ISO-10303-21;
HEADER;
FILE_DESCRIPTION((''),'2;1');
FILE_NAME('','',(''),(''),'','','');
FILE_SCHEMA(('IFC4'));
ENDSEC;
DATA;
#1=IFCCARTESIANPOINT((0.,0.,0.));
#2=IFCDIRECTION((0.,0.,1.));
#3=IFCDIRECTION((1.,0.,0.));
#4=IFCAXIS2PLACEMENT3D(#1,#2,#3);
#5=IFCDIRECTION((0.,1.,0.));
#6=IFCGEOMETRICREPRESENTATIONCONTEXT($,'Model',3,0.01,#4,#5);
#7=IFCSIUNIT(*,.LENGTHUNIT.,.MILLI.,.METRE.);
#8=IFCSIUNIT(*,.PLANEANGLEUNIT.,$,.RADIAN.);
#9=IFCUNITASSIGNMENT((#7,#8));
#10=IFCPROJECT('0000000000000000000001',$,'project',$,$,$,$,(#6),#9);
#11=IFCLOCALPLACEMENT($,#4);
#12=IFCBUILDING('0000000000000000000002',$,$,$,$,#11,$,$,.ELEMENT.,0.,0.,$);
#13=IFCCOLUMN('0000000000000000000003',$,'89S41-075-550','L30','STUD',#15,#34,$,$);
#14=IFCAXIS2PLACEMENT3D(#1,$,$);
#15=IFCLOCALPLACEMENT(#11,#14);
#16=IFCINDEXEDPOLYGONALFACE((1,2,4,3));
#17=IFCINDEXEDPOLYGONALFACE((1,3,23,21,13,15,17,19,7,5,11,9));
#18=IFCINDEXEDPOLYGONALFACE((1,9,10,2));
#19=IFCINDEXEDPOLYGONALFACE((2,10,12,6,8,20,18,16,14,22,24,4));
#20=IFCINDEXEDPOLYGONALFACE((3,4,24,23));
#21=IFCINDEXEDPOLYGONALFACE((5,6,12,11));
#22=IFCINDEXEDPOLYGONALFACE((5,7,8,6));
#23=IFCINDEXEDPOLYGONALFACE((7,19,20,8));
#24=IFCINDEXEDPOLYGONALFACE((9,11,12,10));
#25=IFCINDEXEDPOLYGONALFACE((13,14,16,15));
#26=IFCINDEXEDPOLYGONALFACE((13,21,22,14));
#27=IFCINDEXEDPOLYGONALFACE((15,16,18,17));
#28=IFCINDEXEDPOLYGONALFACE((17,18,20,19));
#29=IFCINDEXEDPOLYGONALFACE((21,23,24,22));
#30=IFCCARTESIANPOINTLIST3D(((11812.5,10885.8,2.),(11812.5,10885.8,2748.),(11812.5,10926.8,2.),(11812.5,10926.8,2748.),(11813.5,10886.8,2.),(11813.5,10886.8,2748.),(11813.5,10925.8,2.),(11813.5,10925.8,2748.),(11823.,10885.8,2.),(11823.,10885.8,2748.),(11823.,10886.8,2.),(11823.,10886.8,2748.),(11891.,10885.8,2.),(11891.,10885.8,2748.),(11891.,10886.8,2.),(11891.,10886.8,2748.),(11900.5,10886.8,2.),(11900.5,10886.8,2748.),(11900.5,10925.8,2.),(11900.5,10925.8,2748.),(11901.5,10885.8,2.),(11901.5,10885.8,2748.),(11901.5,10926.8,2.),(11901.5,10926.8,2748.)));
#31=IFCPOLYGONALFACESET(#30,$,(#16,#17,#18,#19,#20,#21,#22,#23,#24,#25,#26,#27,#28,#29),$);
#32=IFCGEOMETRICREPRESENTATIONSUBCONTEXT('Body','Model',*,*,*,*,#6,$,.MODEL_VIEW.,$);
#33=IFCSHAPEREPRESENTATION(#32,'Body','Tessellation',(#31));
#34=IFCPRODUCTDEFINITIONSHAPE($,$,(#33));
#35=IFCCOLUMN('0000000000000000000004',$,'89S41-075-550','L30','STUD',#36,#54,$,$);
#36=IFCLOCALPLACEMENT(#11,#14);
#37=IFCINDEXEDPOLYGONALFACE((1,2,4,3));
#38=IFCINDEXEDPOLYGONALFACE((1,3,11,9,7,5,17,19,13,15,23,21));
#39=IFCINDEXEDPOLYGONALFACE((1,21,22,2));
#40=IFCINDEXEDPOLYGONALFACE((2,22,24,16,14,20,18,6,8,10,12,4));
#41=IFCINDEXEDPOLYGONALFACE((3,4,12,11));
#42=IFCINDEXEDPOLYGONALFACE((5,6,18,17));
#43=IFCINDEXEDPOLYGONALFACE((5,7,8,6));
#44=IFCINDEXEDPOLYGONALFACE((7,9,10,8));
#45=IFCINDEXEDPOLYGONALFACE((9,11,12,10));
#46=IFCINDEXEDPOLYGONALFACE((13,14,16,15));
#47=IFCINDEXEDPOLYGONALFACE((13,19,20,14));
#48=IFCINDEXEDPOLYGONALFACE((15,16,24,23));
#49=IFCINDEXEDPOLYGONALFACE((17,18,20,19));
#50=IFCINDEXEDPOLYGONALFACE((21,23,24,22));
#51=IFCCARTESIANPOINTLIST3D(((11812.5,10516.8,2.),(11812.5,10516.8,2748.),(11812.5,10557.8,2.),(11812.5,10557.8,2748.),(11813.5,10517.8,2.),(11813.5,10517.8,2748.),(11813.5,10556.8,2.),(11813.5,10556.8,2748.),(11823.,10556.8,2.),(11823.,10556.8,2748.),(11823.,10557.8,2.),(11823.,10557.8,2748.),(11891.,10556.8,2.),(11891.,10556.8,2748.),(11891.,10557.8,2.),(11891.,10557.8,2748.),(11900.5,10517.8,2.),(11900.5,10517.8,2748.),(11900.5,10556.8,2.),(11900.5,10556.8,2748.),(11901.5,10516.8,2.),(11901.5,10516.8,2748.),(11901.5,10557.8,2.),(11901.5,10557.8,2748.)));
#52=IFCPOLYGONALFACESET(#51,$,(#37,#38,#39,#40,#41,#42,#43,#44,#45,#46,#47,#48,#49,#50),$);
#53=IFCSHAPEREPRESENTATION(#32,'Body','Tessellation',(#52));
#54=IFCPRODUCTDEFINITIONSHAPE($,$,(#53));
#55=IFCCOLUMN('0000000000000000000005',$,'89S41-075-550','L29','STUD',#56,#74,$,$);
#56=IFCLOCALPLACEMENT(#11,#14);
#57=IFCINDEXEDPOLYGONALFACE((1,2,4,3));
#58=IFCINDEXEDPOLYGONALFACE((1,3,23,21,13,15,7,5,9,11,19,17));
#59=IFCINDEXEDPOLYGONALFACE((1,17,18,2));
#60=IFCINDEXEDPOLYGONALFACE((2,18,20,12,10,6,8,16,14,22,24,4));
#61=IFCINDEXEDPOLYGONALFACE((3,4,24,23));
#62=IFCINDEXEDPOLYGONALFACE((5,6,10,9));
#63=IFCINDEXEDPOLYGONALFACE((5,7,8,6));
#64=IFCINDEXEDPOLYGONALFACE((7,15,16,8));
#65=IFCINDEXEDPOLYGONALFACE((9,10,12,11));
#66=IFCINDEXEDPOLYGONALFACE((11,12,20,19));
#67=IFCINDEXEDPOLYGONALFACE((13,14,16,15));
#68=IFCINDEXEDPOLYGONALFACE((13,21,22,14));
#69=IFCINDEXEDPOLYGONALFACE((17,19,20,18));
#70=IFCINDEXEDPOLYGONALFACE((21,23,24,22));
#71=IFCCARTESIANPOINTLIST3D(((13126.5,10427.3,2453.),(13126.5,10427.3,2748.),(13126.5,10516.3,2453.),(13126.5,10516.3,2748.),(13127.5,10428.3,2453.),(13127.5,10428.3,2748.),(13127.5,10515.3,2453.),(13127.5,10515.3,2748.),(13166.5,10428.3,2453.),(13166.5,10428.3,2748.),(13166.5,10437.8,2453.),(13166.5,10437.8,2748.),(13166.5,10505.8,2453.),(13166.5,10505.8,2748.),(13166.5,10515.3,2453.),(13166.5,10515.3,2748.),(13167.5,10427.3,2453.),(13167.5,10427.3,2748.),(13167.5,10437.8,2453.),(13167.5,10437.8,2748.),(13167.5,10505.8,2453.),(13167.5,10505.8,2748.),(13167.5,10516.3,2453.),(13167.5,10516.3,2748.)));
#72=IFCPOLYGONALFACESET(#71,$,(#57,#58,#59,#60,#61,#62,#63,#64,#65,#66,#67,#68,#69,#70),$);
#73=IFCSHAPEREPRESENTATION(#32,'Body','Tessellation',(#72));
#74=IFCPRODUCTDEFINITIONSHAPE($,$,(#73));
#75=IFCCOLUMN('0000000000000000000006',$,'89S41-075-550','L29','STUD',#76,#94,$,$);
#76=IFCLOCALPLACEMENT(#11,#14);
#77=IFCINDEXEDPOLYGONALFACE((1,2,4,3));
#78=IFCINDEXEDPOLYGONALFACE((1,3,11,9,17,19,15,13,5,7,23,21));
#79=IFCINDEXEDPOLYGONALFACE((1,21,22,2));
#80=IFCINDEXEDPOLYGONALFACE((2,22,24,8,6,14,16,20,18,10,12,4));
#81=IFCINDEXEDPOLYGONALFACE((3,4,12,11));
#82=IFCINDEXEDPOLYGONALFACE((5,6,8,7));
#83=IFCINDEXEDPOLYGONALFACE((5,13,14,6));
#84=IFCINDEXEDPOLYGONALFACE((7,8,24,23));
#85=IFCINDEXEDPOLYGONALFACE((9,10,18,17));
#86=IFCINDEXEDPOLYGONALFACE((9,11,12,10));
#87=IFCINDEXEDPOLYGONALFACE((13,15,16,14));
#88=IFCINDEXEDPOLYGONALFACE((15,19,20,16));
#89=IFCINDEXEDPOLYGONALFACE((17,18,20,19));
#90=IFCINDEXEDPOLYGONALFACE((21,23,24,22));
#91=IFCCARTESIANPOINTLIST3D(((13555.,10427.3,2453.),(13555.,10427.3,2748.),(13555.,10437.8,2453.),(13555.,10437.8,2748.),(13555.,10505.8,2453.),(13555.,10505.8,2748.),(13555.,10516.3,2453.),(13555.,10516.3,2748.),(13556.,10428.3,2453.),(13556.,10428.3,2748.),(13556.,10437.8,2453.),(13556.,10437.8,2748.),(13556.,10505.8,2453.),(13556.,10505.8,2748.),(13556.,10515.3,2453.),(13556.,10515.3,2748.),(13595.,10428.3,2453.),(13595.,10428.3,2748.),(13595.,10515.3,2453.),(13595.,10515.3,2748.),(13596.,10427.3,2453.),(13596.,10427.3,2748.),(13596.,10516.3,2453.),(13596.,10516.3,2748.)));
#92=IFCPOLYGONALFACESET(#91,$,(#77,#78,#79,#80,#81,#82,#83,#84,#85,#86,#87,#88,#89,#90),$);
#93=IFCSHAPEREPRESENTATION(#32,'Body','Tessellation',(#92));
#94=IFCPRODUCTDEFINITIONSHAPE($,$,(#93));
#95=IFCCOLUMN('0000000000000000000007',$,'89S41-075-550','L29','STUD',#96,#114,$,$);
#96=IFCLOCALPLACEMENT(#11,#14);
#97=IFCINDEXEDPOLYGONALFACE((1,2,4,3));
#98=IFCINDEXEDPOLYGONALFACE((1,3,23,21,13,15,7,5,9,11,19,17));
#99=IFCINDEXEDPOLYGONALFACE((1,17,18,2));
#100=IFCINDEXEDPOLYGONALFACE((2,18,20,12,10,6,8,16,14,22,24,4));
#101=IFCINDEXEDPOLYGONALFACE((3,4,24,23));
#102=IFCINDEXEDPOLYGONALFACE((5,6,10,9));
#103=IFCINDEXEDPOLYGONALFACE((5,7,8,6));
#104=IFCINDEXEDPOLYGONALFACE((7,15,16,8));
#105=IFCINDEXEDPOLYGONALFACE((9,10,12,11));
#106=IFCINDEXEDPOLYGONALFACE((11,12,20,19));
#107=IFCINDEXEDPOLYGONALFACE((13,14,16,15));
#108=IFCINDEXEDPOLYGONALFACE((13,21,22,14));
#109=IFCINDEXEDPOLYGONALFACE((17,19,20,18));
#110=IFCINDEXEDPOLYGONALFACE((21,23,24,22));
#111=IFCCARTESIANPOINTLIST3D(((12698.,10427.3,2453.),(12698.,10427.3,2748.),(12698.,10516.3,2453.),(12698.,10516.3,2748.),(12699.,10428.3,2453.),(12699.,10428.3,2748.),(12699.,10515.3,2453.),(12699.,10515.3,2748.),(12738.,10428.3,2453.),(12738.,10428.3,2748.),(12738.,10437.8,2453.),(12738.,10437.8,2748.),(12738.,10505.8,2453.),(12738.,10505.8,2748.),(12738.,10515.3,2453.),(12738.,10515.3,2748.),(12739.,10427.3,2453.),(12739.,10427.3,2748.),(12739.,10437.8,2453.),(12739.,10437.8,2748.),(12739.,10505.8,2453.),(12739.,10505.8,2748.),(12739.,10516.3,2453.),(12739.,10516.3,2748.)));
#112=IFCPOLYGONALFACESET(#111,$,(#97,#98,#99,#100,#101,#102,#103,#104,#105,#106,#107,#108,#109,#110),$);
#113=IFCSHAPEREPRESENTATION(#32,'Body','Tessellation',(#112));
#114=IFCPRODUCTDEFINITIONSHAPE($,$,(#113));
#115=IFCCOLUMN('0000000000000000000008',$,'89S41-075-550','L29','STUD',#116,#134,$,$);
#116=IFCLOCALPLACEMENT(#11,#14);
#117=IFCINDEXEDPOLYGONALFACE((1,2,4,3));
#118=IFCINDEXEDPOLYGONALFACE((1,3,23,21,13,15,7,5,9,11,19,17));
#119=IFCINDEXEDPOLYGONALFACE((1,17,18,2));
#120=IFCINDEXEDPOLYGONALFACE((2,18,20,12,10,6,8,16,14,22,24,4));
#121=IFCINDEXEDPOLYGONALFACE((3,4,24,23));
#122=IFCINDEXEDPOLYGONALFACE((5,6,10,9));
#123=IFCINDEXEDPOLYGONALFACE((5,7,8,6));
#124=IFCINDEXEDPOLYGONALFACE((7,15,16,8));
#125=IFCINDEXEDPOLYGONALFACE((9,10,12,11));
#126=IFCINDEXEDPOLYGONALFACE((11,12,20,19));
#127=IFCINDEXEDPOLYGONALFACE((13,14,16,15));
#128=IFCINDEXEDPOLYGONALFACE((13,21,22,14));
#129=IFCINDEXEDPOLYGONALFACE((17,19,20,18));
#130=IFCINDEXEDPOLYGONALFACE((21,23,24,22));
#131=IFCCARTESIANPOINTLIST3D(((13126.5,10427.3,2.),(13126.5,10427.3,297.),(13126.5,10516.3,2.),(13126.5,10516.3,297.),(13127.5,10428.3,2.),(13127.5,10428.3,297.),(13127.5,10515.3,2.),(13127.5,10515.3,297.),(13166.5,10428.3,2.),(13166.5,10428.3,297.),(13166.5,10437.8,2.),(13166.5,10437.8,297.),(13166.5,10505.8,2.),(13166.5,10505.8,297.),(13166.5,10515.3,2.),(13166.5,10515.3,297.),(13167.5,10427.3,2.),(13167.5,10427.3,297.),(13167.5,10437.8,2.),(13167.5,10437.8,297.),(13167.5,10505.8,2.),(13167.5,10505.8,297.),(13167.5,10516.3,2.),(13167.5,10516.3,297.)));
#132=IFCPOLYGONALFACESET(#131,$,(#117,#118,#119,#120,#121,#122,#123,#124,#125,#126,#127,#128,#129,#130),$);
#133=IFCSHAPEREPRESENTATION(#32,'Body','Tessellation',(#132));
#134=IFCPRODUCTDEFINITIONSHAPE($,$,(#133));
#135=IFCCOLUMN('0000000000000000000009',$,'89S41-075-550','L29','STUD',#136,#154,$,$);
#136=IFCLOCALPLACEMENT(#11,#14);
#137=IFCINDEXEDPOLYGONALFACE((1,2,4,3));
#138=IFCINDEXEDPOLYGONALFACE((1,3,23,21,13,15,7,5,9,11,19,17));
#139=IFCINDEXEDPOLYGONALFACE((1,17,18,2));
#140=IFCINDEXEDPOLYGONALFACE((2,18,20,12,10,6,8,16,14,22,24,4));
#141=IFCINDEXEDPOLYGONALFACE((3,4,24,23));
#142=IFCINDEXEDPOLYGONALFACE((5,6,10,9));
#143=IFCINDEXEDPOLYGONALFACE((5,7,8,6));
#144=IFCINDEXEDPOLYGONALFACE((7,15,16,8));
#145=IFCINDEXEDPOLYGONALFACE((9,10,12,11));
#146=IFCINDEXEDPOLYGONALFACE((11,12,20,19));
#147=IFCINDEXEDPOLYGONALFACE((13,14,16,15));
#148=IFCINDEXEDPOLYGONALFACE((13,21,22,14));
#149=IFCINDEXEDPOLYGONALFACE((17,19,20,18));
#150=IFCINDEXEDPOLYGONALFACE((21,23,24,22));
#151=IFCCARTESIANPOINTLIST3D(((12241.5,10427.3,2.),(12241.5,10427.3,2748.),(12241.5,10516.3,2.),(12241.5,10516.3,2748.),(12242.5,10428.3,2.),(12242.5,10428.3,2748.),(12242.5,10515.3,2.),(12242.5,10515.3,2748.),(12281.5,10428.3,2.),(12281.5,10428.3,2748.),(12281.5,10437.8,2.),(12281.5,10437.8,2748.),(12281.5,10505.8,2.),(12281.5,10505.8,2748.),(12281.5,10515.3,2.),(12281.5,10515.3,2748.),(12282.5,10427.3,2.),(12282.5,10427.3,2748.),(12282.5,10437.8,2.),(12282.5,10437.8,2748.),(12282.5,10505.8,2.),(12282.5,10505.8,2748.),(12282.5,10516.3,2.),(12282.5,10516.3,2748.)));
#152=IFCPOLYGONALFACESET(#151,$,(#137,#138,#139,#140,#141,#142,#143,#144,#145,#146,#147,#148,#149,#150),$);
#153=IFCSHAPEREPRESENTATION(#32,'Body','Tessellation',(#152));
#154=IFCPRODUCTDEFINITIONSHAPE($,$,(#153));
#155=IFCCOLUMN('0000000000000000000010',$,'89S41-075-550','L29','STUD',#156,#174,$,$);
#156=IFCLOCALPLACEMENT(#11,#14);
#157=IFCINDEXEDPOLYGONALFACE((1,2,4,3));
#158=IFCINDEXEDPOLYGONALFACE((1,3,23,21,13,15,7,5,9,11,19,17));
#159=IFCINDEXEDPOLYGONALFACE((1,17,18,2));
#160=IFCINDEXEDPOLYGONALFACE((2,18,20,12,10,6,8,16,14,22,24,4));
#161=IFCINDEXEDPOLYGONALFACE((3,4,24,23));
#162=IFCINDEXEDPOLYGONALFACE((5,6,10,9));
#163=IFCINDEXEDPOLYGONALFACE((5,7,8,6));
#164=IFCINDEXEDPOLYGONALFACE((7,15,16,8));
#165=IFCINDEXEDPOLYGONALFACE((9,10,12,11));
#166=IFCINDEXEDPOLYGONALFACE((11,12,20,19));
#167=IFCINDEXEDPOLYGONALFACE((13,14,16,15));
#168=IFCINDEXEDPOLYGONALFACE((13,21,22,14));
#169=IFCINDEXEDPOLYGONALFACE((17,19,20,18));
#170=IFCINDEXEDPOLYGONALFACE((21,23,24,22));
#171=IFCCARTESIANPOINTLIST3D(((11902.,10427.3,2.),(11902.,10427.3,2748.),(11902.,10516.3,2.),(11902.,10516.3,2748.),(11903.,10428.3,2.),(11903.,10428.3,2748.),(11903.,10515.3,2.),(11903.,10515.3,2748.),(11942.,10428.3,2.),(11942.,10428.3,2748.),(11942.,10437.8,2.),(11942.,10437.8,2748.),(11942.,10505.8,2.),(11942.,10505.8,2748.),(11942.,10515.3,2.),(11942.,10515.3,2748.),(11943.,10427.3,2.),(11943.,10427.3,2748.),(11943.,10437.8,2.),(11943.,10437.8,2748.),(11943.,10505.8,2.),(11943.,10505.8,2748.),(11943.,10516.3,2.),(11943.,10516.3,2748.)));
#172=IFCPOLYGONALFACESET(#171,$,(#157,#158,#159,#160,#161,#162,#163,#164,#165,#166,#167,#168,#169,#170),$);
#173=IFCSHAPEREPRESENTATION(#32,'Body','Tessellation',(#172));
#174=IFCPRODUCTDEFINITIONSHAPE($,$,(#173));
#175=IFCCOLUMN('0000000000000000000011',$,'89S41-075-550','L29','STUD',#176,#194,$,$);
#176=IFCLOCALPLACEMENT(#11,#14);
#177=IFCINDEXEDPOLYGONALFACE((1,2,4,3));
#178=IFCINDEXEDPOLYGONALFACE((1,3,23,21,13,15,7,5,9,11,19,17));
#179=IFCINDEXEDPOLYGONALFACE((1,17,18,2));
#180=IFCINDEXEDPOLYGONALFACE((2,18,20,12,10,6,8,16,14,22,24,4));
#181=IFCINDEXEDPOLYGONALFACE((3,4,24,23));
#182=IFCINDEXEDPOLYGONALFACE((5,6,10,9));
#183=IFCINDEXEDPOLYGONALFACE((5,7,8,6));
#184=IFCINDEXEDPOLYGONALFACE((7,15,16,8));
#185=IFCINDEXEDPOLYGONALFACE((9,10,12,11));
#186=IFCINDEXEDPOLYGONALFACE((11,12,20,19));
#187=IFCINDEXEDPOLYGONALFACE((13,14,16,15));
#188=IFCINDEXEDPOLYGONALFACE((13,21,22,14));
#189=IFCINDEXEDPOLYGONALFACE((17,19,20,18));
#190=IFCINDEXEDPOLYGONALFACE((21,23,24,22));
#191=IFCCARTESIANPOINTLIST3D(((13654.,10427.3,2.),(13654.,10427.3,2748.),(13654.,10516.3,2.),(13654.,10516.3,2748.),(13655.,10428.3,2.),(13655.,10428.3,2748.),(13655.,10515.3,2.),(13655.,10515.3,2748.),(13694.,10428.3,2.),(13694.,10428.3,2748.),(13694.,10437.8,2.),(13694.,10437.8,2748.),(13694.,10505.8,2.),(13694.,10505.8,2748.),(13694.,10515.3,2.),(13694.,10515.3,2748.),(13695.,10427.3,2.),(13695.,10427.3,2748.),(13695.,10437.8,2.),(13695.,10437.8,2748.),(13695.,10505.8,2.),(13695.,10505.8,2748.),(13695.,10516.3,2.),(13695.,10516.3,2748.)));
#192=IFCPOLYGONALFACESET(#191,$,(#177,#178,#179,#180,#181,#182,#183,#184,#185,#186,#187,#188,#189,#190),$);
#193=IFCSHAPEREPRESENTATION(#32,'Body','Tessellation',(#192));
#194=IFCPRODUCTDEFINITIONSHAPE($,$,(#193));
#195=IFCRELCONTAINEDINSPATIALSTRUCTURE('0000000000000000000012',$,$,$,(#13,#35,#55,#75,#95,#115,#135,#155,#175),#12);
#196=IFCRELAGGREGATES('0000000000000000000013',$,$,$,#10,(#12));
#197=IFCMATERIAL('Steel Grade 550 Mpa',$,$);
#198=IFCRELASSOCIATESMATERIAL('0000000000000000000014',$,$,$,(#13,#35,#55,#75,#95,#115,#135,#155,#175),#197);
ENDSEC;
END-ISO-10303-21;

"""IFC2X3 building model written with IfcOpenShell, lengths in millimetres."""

from ifc_helpers import new_model, si_unit, direction, frame, origin, origin_with_axes, origin_2d_with_axis, place, context, subcontext, project, spatial, c_section, extrude, source, transform, mapped, material, element, save


model = new_model("IFC2X3")

# Units and contexts
model_context = context("Model", 3, precision=0.01, world=origin_with_axes(), true_north=direction((0.0, 1.0, 0.0)))
body_context = subcontext(model_context, "Body", "Model", "MODEL_VIEW")
ifc_project = project(units=[si_unit("LENGTHUNIT", "METRE", prefix="MILLI"), si_unit("PLANEANGLEUNIT", "RADIAN")], contexts=[model_context])

# Building
building_placement = place(None, origin_with_axes())
building = spatial("IfcBuilding", under=ifc_project, at=building_placement, CompositionType="ELEMENT", ElevationOfRefHeight=0.0, ElevationOfTerrain=0.0)

# Columns
ifc_material = material(Name="Steel Grade 550 Mpa")
shared_shape_1 = source(origin(), body_context, "Body", "SweptSolid", [
    extrude(c_section(Depth=89.0, Width=41.0, WallThickness=1.0, Girth=10.5, at=origin_2d_with_axis()), origin_with_axes(), (0.0, 0.0, 1.0), 2746.0),
])
column_1_placement = place(None, frame((11857.0, 10906.3, 2.0), z_axis=(0.0, 0.0, 1.0), x_axis=(0.0, -1.0, 0.0)))
element("IfcColumn", 1, at=column_1_placement, inside=building, material=ifc_material, Name="89S41-075-550", Description="L30", ObjectType="STUD", context=body_context, shape_type="MappedRepresentation", body=[
    mapped(shared_shape_1, transform((0.0, 0.0, 0.0), scale=1.0)),
])
shared_shape_2 = source(origin(), body_context, "Body", "SweptSolid", [
    extrude(c_section(Depth=89.0, Width=41.0, WallThickness=1.0, Girth=10.5, at=origin_2d_with_axis()), origin_with_axes(), (0.0, 0.0, 1.0), 2746.0),
])
column_2_placement = place(None, frame((11857.0, 10537.3, 2.0), z_axis=(0.0, 0.0, 1.0), x_axis=(0.0, 1.0, 0.0)))
element("IfcColumn", 2, at=column_2_placement, inside=building, material=ifc_material, Name="89S41-075-550", Description="L30", ObjectType="STUD", context=body_context, shape_type="MappedRepresentation", body=[
    mapped(shared_shape_2, transform((0.0, 0.0, 0.0), scale=1.0)),
])
shared_shape_3 = source(origin(), body_context, "Body", "SweptSolid", [
    extrude(c_section(Depth=89.0, Width=41.0, WallThickness=1.0, Girth=10.5, at=origin_2d_with_axis()), origin_with_axes(), (0.0, 0.0, 1.0), 295.0),
])
column_3_placement = place(None, frame((13147.0, 10471.8, 2453.0), z_axis=(0.0, 0.0, 1.0), x_axis=(1.0, 0.0, 0.0)))
element("IfcColumn", 3, at=column_3_placement, inside=building, material=ifc_material, Name="89S41-075-550", Description="L29", ObjectType="STUD", context=body_context, shape_type="MappedRepresentation", body=[
    mapped(shared_shape_3, transform((0.0, 0.0, 0.0), scale=1.0)),
])
shared_shape_4 = source(origin(), body_context, "Body", "SweptSolid", [
    extrude(c_section(Depth=89.0, Width=41.0, WallThickness=1.0, Girth=10.5, at=origin_2d_with_axis()), origin_with_axes(), (0.0, 0.0, 1.0), 295.0),
])
column_4_placement = place(None, frame((13575.5, 10471.8, 2453.0), z_axis=(0.0, 0.0, 1.0), x_axis=(-1.0, 0.0, 0.0)))
element("IfcColumn", 4, at=column_4_placement, inside=building, material=ifc_material, Name="89S41-075-550", Description="L29", ObjectType="STUD", context=body_context, shape_type="MappedRepresentation", body=[
    mapped(shared_shape_4, transform((0.0, 0.0, 0.0), scale=1.0)),
])
shared_shape_5 = source(origin(), body_context, "Body", "SweptSolid", [
    extrude(c_section(Depth=89.0, Width=41.0, WallThickness=1.0, Girth=10.5, at=origin_2d_with_axis()), origin_with_axes(), (0.0, 0.0, 1.0), 295.0),
])
column_5_placement = place(None, frame((12718.5, 10471.8, 2453.0), z_axis=(0.0, 0.0, 1.0), x_axis=(1.0, 0.0, 0.0)))
element("IfcColumn", 5, at=column_5_placement, inside=building, material=ifc_material, Name="89S41-075-550", Description="L29", ObjectType="STUD", context=body_context, shape_type="MappedRepresentation", body=[
    mapped(shared_shape_5, transform((0.0, 0.0, 0.0), scale=1.0)),
])
shared_shape_6 = source(origin(), body_context, "Body", "SweptSolid", [
    extrude(c_section(Depth=89.0, Width=41.0, WallThickness=1.0, Girth=10.5, at=origin_2d_with_axis()), origin_with_axes(), (0.0, 0.0, 1.0), 295.0),
])
column_6_placement = place(None, frame((13147.0, 10471.8, 2.0), z_axis=(0.0, 0.0, 1.0), x_axis=(1.0, 0.0, 0.0)))
element("IfcColumn", 6, at=column_6_placement, inside=building, material=ifc_material, Name="89S41-075-550", Description="L29", ObjectType="STUD", context=body_context, shape_type="MappedRepresentation", body=[
    mapped(shared_shape_6, transform((0.0, 0.0, 0.0), scale=1.0)),
])
shared_shape_7 = source(origin(), body_context, "Body", "SweptSolid", [
    extrude(c_section(Depth=89.0, Width=41.0, WallThickness=1.0, Girth=10.5, at=origin_2d_with_axis()), origin_with_axes(), (0.0, 0.0, 1.0), 2746.0),
])
column_7_placement = place(None, frame((12262.0, 10471.8, 2.0), z_axis=(0.0, 0.0, 1.0), x_axis=(1.0, 0.0, 0.0)))
element("IfcColumn", 7, at=column_7_placement, inside=building, material=ifc_material, Name="89S41-075-550", Description="L29", ObjectType="STUD", context=body_context, shape_type="MappedRepresentation", body=[
    mapped(shared_shape_7, transform((0.0, 0.0, 0.0), scale=1.0)),
])
shared_shape_8 = source(origin(), body_context, "Body", "SweptSolid", [
    extrude(c_section(Depth=89.0, Width=41.0, WallThickness=1.0, Girth=10.5, at=origin_2d_with_axis()), origin_with_axes(), (0.0, 0.0, 1.0), 2746.0),
])
column_8_placement = place(None, frame((11922.5, 10471.8, 2.0), z_axis=(0.0, 0.0, 1.0), x_axis=(1.0, 0.0, 0.0)))
element("IfcColumn", 8, at=column_8_placement, inside=building, material=ifc_material, Name="89S41-075-550", Description="L29", ObjectType="STUD", context=body_context, shape_type="MappedRepresentation", body=[
    mapped(shared_shape_8, transform((0.0, 0.0, 0.0), scale=1.0)),
])
shared_shape_9 = source(origin(), body_context, "Body", "SweptSolid", [
    extrude(c_section(Depth=89.0, Width=41.0, WallThickness=1.0, Girth=10.5, at=origin_2d_with_axis()), origin_with_axes(), (0.0, 0.0, 1.0), 2746.0),
])
column_9_placement = place(None, frame((13674.5, 10471.8, 2.0), z_axis=(0.0, 0.0, 1.0), x_axis=(1.0, 0.0, 0.0)))
element("IfcColumn", 9, at=column_9_placement, inside=building, material=ifc_material, Name="89S41-075-550", Description="L29", ObjectType="STUD", context=body_context, shape_type="MappedRepresentation", body=[
    mapped(shared_shape_9, transform((0.0, 0.0, 0.0), scale=1.0)),
])

save(model, "model.ifc")
